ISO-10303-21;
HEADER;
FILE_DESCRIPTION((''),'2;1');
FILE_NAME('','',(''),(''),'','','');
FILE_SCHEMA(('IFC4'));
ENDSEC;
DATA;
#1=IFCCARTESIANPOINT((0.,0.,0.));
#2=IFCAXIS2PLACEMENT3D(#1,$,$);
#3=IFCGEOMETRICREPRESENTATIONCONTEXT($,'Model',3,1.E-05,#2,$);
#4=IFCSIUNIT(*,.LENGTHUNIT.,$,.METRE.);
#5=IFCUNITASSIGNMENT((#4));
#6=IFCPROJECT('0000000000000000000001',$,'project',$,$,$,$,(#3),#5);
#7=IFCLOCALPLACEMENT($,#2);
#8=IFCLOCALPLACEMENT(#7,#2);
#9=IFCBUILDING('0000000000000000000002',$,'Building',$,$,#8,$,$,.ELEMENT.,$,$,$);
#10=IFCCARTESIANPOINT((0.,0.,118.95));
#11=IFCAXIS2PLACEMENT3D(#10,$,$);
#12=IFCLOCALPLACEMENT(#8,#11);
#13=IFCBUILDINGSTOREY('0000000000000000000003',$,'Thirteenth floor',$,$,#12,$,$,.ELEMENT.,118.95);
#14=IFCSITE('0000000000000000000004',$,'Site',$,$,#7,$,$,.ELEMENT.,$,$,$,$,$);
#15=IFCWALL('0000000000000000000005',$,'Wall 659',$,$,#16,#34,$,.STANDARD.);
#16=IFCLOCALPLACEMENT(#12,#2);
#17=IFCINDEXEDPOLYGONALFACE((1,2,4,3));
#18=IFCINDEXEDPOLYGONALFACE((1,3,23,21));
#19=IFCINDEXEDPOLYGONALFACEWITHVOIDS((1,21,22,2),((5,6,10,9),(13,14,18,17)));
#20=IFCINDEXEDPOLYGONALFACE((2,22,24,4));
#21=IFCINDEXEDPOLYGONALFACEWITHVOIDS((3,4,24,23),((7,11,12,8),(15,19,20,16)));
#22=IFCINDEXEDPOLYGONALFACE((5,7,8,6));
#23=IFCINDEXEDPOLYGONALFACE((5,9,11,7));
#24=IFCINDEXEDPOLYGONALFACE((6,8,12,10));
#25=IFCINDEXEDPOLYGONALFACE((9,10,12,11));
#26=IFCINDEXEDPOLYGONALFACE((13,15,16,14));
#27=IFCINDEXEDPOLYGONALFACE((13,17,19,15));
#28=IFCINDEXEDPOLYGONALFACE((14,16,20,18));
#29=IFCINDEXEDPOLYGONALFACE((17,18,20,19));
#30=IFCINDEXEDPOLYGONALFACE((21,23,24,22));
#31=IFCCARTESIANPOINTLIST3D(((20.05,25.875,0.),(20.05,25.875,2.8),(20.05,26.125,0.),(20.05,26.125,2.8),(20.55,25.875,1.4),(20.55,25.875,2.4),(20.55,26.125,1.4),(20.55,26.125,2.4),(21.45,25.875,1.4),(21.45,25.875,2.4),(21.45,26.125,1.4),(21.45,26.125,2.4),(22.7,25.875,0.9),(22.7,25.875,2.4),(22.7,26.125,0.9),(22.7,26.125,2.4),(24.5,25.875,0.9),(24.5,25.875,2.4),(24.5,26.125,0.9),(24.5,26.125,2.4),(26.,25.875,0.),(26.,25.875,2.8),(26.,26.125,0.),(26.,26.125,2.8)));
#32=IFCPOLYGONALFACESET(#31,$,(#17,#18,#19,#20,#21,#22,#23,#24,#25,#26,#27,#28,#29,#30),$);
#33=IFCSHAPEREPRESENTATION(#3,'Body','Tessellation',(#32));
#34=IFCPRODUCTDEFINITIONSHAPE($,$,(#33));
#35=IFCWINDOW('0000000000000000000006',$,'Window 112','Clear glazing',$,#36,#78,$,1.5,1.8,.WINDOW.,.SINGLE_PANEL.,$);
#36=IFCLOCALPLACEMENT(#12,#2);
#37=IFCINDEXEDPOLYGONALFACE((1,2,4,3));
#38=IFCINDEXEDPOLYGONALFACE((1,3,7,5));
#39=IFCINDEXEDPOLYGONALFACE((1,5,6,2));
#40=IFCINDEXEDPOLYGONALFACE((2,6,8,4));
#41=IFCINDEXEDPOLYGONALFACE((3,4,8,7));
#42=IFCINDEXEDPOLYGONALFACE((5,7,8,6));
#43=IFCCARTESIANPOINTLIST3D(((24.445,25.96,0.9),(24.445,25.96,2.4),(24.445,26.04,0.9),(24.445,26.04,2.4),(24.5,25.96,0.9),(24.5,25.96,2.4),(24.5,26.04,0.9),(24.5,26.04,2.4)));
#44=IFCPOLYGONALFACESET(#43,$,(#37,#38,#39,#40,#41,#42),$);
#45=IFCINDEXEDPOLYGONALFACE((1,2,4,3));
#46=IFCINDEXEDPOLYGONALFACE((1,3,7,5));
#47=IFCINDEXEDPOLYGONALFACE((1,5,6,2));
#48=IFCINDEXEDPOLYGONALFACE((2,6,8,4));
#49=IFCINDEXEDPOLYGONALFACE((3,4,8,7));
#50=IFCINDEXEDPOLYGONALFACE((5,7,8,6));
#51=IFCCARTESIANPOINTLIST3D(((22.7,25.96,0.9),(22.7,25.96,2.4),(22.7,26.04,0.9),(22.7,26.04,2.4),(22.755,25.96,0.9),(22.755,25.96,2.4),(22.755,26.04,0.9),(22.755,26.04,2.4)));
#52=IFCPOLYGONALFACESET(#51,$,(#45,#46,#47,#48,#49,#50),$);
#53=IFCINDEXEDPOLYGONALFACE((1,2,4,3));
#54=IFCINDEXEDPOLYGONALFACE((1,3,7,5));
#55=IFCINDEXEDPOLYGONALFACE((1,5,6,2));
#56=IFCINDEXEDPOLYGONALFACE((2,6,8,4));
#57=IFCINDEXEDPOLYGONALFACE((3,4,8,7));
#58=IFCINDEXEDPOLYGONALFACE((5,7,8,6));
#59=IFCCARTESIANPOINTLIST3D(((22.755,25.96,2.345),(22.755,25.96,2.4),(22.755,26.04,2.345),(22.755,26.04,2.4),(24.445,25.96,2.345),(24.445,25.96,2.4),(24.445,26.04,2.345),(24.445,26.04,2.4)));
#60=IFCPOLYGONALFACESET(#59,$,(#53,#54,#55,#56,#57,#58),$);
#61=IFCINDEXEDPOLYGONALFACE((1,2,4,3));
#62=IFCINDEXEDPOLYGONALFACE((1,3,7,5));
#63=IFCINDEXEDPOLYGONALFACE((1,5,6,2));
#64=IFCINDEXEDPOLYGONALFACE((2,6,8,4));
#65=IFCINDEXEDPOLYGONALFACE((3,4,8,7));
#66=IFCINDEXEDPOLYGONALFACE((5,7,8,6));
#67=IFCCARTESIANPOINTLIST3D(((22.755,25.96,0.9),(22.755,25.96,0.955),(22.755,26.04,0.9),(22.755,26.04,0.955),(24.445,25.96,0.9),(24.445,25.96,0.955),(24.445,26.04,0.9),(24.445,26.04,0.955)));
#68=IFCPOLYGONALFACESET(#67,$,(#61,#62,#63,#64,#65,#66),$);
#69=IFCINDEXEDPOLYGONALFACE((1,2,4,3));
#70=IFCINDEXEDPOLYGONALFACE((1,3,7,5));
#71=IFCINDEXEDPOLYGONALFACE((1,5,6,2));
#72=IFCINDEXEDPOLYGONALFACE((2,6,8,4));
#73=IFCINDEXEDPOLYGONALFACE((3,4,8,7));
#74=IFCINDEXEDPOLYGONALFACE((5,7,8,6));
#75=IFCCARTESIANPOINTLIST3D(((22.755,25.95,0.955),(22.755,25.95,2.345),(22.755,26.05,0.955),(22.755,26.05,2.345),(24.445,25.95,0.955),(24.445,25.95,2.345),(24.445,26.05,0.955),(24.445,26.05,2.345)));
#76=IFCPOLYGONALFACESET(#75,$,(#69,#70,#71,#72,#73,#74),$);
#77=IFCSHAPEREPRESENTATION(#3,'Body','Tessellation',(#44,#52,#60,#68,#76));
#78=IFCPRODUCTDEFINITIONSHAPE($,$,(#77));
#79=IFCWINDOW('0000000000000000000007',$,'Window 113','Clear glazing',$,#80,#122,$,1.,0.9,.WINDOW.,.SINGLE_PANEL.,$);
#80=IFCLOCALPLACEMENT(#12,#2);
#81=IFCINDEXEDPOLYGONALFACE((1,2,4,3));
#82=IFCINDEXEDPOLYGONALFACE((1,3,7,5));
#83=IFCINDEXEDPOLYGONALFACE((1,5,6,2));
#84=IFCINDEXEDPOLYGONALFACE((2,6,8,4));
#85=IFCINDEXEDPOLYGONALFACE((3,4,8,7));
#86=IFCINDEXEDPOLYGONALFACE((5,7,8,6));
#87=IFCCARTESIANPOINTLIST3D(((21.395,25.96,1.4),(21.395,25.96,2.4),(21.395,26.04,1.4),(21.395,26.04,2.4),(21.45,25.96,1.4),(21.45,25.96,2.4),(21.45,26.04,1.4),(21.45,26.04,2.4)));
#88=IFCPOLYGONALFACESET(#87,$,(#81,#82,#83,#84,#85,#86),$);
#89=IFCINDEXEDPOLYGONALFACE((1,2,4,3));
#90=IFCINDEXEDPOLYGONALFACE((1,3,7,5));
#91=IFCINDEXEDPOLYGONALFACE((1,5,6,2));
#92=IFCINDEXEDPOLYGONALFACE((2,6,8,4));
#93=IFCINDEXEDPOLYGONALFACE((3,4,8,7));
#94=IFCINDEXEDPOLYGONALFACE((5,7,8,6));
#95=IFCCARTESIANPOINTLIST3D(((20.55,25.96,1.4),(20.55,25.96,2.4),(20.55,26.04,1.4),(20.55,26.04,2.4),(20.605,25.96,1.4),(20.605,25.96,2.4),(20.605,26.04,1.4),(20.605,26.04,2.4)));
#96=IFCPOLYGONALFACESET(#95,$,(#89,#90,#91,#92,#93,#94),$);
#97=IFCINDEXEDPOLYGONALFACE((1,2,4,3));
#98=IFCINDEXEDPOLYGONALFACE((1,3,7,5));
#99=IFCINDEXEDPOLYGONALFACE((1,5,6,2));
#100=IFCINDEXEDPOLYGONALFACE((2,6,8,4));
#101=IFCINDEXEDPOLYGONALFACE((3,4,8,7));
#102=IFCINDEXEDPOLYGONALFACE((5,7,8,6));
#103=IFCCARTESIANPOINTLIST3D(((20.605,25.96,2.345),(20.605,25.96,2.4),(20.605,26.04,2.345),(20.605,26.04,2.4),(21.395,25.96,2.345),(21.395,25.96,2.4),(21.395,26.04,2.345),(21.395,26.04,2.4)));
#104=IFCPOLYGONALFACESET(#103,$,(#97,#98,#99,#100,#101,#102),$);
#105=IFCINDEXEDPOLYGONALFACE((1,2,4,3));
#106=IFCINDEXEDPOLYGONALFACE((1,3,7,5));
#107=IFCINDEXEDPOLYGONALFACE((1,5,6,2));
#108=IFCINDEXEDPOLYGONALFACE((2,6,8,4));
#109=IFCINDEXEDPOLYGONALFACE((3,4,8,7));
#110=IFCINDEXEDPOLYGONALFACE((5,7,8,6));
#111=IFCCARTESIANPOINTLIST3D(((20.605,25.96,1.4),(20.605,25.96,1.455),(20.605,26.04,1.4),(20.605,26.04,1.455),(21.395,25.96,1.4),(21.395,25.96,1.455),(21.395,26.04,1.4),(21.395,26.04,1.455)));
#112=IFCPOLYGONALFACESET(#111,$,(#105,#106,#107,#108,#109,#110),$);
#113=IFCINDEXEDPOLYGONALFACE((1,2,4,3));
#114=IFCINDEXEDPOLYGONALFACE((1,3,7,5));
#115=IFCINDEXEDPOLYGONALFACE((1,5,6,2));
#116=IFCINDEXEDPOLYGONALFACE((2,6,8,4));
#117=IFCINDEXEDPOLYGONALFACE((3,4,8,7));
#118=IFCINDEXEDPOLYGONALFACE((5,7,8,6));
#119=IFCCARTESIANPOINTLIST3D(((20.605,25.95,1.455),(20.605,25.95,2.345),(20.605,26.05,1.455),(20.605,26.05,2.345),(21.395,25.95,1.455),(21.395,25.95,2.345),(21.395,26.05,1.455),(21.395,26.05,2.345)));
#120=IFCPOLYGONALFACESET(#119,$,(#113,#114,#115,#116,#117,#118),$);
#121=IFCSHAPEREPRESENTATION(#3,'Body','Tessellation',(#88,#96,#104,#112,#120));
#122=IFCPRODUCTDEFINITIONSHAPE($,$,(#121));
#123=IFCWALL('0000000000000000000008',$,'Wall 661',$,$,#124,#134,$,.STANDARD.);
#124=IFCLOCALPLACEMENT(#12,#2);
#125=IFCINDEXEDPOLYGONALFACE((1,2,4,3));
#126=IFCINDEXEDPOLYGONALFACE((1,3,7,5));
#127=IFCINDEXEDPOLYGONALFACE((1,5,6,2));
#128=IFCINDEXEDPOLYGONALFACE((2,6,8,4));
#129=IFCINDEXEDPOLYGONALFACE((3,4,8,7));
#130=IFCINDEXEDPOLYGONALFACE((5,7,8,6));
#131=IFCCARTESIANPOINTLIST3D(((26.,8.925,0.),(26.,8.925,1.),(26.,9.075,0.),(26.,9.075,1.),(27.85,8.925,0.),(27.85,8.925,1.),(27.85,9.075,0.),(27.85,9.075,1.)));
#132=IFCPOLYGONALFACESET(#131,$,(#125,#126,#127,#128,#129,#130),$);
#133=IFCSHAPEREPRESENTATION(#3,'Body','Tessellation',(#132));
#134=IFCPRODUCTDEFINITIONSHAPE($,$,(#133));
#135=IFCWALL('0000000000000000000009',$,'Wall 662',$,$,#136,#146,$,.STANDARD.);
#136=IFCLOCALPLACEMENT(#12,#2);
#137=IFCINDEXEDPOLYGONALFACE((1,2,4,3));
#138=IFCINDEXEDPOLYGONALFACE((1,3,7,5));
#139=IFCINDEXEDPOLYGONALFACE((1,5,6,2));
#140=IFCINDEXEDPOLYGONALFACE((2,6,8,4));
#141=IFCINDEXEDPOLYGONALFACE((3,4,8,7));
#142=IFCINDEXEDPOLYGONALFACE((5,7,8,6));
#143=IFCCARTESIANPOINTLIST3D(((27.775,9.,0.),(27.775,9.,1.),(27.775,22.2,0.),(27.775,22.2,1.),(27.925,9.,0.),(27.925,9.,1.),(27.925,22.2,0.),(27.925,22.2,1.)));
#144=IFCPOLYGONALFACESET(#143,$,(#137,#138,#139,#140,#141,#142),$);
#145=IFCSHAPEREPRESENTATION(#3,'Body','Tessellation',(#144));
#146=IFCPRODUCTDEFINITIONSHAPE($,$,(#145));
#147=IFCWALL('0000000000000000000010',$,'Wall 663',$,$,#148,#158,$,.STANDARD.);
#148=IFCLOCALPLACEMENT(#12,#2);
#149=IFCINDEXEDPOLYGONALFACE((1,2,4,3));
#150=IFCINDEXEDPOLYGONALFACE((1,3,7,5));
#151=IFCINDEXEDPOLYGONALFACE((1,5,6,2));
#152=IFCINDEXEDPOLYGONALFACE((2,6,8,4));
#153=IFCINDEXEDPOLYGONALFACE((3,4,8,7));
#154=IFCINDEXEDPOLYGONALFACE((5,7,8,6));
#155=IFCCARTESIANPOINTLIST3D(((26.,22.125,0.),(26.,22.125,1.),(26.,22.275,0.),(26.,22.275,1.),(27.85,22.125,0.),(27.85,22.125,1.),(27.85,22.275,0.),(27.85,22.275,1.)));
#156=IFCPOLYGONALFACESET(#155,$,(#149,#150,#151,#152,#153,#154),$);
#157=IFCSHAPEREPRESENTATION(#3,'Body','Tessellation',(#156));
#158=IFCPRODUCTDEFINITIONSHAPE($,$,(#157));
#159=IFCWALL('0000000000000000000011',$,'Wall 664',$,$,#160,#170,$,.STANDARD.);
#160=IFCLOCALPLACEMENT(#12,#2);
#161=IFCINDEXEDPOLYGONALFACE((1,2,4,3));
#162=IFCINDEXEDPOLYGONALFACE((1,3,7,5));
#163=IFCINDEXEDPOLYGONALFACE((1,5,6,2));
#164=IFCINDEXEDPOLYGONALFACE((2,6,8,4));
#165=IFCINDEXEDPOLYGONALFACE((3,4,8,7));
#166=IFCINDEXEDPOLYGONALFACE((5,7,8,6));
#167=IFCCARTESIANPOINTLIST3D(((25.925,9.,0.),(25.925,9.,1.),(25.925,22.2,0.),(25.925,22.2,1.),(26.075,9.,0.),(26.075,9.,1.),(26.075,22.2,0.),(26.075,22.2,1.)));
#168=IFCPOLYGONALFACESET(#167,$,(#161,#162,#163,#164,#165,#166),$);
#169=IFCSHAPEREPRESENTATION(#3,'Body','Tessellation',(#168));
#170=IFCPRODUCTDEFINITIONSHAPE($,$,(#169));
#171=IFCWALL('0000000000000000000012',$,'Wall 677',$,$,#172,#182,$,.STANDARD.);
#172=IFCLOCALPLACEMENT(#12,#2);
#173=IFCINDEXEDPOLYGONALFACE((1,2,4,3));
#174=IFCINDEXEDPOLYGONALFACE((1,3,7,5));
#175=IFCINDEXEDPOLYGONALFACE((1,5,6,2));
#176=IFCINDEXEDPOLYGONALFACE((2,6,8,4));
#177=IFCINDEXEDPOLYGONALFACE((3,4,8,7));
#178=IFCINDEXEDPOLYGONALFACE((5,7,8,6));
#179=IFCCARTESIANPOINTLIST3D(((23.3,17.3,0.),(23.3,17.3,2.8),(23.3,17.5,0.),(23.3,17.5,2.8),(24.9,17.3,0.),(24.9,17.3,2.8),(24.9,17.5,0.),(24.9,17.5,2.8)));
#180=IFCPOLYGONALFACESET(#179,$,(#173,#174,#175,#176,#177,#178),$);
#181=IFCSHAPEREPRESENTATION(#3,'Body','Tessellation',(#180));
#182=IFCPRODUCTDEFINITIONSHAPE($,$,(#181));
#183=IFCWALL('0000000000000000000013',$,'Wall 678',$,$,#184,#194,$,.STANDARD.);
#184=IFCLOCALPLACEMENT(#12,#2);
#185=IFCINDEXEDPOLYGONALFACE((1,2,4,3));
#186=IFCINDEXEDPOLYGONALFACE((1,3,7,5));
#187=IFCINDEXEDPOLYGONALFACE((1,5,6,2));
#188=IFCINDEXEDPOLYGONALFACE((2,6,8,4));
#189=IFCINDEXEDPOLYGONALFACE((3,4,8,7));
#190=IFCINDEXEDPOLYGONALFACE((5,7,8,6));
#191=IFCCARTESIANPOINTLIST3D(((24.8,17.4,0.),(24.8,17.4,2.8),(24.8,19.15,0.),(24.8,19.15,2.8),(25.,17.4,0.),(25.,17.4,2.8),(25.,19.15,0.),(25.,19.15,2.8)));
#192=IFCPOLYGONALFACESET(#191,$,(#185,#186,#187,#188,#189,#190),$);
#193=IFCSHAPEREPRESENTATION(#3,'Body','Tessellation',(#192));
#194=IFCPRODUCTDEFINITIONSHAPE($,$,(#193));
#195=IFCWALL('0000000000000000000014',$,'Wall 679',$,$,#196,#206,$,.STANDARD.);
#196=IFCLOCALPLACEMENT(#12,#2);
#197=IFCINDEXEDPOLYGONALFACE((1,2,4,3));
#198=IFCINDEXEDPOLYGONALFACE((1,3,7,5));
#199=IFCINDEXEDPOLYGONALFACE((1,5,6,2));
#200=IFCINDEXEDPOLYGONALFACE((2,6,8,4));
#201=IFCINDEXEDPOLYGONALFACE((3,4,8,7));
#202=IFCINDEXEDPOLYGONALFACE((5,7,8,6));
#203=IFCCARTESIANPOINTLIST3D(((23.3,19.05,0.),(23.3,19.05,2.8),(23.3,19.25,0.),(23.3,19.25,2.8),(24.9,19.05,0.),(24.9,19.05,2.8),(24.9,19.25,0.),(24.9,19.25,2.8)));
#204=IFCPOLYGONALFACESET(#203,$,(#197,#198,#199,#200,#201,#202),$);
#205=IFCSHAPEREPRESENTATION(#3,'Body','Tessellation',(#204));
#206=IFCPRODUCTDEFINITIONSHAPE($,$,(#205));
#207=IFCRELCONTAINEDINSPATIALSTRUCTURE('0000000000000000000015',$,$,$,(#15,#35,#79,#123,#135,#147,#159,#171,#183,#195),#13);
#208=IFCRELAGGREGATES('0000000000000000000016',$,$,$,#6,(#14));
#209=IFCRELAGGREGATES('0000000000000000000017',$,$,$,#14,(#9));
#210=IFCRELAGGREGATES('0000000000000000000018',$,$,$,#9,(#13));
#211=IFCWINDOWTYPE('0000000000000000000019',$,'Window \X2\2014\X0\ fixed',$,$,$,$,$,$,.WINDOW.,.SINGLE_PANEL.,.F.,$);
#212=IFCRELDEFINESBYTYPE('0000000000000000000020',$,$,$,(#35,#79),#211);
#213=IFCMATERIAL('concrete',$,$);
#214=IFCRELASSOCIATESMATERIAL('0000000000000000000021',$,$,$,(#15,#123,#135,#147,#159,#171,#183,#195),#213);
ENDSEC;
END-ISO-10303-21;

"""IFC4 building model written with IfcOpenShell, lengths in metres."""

from ifc_helpers import new_model, si_unit, frame, frame_2d, origin, place, context, project, spatial, rectangle, extrude, material, type_object, element, fill, save


model = new_model("IFC4")

# Units and contexts
model_context = context("Model", 3, precision=1e-05, world=origin())
ifc_project = project(units=[si_unit("LENGTHUNIT", "METRE")], contexts=[model_context])

# Site, building, storey
site_placement = place(None, origin())
site = spatial("IfcSite", under=ifc_project, at=site_placement, Name="Site", CompositionType="ELEMENT")
building_placement = place(site_placement, origin())
building = spatial("IfcBuilding", under=site, at=building_placement, Name="Building", CompositionType="ELEMENT")
storey_placement = place(building_placement, frame((0.0, 0.0, 118.95)))
storey = spatial("IfcBuildingStorey", under=building, at=storey_placement, Name="Thirteenth floor", CompositionType="ELEMENT", Elevation=118.95)

# Shared definitions
ifc_material = material(Name="concrete")

# Shared definitions
window_type = type_object("IfcWindowType", Name="Window — fixed", ParameterTakesPrecedence=False, PartitioningType="SINGLE_PANEL", PredefinedType="WINDOW")

# Wall, openings, windows
wall_1_placement = place(storey_placement, frame((26.0, 26.0, 0.0), z_axis=(0.0, 0.0, 1.0), x_axis=(-1.0, 0.0, 0.0)))
wall_1 = element("IfcWall", 1, at=wall_1_placement, inside=storey, material=ifc_material, Name="Wall 659", PredefinedType="STANDARD", context=model_context, shape_type="SweptSolid", body=[
    extrude(rectangle(XDim=5.95, YDim=0.25, at=frame_2d((2.975, 0.0))), origin(), (0.0, 0.0, 1.0), 2.8),
])
opening_1_placement = place(storey_placement, frame((24.5, 26.0, 0.9), z_axis=(0.0, 0.0, 1.0), x_axis=(-1.0, 0.0, 0.0)))
opening_1 = element("IfcOpeningElement", 2, at=opening_1_placement, cuts=wall_1, PredefinedType="OPENING", context=model_context, shape_type="SweptSolid", body=[
    extrude(rectangle(XDim=1.8, YDim=0.31, at=frame_2d((0.9, 0.0))), origin(), (0.0, 0.0, 1.0), 1.5),
])
opening_2_placement = place(storey_placement, frame((21.45, 26.0, 1.4), z_axis=(0.0, 0.0, 1.0), x_axis=(-1.0, 0.0, 0.0)))
opening_2 = element("IfcOpeningElement", 3, at=opening_2_placement, cuts=wall_1, PredefinedType="OPENING", context=model_context, shape_type="SweptSolid", body=[
    extrude(rectangle(XDim=0.9, YDim=0.31, at=frame_2d((0.45, 0.0))), origin(), (0.0, 0.0, 1.0), 1.0),
])
window_1_placement = place(storey_placement, frame((24.5, 26.0, 0.9), z_axis=(0.0, 0.0, 1.0), x_axis=(-1.0, 0.0, 0.0)))
window_1 = element("IfcWindow", 4, at=window_1_placement, inside=storey, type_object=window_type, Name="Window 112", Description="Clear glazing", OverallHeight=1.5, OverallWidth=1.8, PartitioningType="SINGLE_PANEL", PredefinedType="WINDOW", context=model_context, shape_type="SweptSolid", body=[
    extrude(rectangle(XDim=0.055, YDim=0.08, at=frame_2d((0.0275, 0.0))), origin(), (0.0, 0.0, 1.0), 1.5),
    extrude(rectangle(XDim=0.055, YDim=0.08, at=frame_2d((1.7725, 0.0))), origin(), (0.0, 0.0, 1.0), 1.5),
    extrude(rectangle(XDim=1.69, YDim=0.08, at=frame_2d((0.9, 0.0))), frame((0.0, 0.0, 1.445)), (0.0, 0.0, 1.0), 0.055),
    extrude(rectangle(XDim=1.69, YDim=0.08, at=frame_2d((0.9, 0.0))), origin(), (0.0, 0.0, 1.0), 0.055),
    extrude(rectangle(XDim=1.69, YDim=0.1, at=frame_2d((0.9, 0.0))), frame((0.0, 0.0, 0.055)), (0.0, 0.0, 1.0), 1.39),
])
fill(opening_1, window_1)
window_2_placement = place(storey_placement, frame((21.45, 26.0, 1.4), z_axis=(0.0, 0.0, 1.0), x_axis=(-1.0, 0.0, 0.0)))
window_2 = element("IfcWindow", 5, at=window_2_placement, inside=storey, type_object=window_type, Name="Window 113", Description="Clear glazing", OverallHeight=1.0, OverallWidth=0.9, PartitioningType="SINGLE_PANEL", PredefinedType="WINDOW", context=model_context, shape_type="SweptSolid", body=[
    extrude(rectangle(XDim=0.055, YDim=0.08, at=frame_2d((0.0275, 0.0))), origin(), (0.0, 0.0, 1.0), 1.0),
    extrude(rectangle(XDim=0.055, YDim=0.08, at=frame_2d((0.8725, 0.0))), origin(), (0.0, 0.0, 1.0), 1.0),
    extrude(rectangle(XDim=0.79, YDim=0.08, at=frame_2d((0.45, 0.0))), frame((0.0, 0.0, 0.945)), (0.0, 0.0, 1.0), 0.055),
    extrude(rectangle(XDim=0.79, YDim=0.08, at=frame_2d((0.45, 0.0))), origin(), (0.0, 0.0, 1.0), 0.055),
    extrude(rectangle(XDim=0.79, YDim=0.1, at=frame_2d((0.45, 0.0))), frame((0.0, 0.0, 0.055)), (0.0, 0.0, 1.0), 0.89),
])
fill(opening_2, window_2)

# Walls
wall_2_placement = place(storey_placement, frame((26.0, 9.0, 0.0), z_axis=(0.0, 0.0, 1.0), x_axis=(1.0, 0.0, 0.0)))
element("IfcWall", 6, at=wall_2_placement, inside=storey, material=ifc_material, Name="Wall 661", PredefinedType="STANDARD", context=model_context, shape_type="SweptSolid", body=[
    extrude(rectangle(XDim=1.85, YDim=0.15, at=frame_2d((0.925, 0.0))), origin(), (0.0, 0.0, 1.0), 1.0),
])
wall_3_placement = place(storey_placement, frame((27.85, 9.0, 0.0), z_axis=(0.0, 0.0, 1.0), x_axis=(0.0, 1.0, 0.0)))
element("IfcWall", 7, at=wall_3_placement, inside=storey, material=ifc_material, Name="Wall 662", PredefinedType="STANDARD", context=model_context, shape_type="SweptSolid", body=[
    extrude(rectangle(XDim=13.2, YDim=0.15, at=frame_2d((6.6, 0.0))), origin(), (0.0, 0.0, 1.0), 1.0),
])
wall_4_placement = place(storey_placement, frame((27.85, 22.2, 0.0), z_axis=(0.0, 0.0, 1.0), x_axis=(-1.0, 0.0, 0.0)))
element("IfcWall", 8, at=wall_4_placement, inside=storey, material=ifc_material, Name="Wall 663", PredefinedType="STANDARD", context=model_context, shape_type="SweptSolid", body=[
    extrude(rectangle(XDim=1.85, YDim=0.15, at=frame_2d((0.925, 0.0))), origin(), (0.0, 0.0, 1.0), 1.0),
])
wall_5_placement = place(storey_placement, frame((26.0, 22.2, 0.0), z_axis=(0.0, 0.0, 1.0), x_axis=(0.0, -1.0, 0.0)))
element("IfcWall", 9, at=wall_5_placement, inside=storey, material=ifc_material, Name="Wall 664", PredefinedType="STANDARD", context=model_context, shape_type="SweptSolid", body=[
    extrude(rectangle(XDim=13.2, YDim=0.15, at=frame_2d((6.6, 0.0))), origin(), (0.0, 0.0, 1.0), 1.0),
])
wall_6_placement = place(storey_placement, frame((23.3, 17.4, 0.0), z_axis=(0.0, 0.0, 1.0), x_axis=(1.0, 0.0, 0.0)))
element("IfcWall", 10, at=wall_6_placement, inside=storey, material=ifc_material, Name="Wall 677", PredefinedType="STANDARD", context=model_context, shape_type="SweptSolid", body=[
    extrude(rectangle(XDim=1.6, YDim=0.2, at=frame_2d((0.8, 0.0))), origin(), (0.0, 0.0, 1.0), 2.8),
])
wall_7_placement = place(storey_placement, frame((24.9, 17.4, 0.0), z_axis=(0.0, 0.0, 1.0), x_axis=(0.0, 1.0, 0.0)))
element("IfcWall", 11, at=wall_7_placement, inside=storey, material=ifc_material, Name="Wall 678", PredefinedType="STANDARD", context=model_context, shape_type="SweptSolid", body=[
    extrude(rectangle(XDim=1.75, YDim=0.2, at=frame_2d((0.875, 0.0))), origin(), (0.0, 0.0, 1.0), 2.8),
])
wall_8_placement = place(storey_placement, frame((24.9, 19.15, 0.0), z_axis=(0.0, 0.0, 1.0), x_axis=(-1.0, 0.0, 0.0)))
element("IfcWall", 12, at=wall_8_placement, inside=storey, material=ifc_material, Name="Wall 679", PredefinedType="STANDARD", context=model_context, shape_type="SweptSolid", body=[
    extrude(rectangle(XDim=1.6, YDim=0.2, at=frame_2d((0.8, 0.0))), origin(), (0.0, 0.0, 1.0), 2.8),
])

save(model, "model.ifc")
